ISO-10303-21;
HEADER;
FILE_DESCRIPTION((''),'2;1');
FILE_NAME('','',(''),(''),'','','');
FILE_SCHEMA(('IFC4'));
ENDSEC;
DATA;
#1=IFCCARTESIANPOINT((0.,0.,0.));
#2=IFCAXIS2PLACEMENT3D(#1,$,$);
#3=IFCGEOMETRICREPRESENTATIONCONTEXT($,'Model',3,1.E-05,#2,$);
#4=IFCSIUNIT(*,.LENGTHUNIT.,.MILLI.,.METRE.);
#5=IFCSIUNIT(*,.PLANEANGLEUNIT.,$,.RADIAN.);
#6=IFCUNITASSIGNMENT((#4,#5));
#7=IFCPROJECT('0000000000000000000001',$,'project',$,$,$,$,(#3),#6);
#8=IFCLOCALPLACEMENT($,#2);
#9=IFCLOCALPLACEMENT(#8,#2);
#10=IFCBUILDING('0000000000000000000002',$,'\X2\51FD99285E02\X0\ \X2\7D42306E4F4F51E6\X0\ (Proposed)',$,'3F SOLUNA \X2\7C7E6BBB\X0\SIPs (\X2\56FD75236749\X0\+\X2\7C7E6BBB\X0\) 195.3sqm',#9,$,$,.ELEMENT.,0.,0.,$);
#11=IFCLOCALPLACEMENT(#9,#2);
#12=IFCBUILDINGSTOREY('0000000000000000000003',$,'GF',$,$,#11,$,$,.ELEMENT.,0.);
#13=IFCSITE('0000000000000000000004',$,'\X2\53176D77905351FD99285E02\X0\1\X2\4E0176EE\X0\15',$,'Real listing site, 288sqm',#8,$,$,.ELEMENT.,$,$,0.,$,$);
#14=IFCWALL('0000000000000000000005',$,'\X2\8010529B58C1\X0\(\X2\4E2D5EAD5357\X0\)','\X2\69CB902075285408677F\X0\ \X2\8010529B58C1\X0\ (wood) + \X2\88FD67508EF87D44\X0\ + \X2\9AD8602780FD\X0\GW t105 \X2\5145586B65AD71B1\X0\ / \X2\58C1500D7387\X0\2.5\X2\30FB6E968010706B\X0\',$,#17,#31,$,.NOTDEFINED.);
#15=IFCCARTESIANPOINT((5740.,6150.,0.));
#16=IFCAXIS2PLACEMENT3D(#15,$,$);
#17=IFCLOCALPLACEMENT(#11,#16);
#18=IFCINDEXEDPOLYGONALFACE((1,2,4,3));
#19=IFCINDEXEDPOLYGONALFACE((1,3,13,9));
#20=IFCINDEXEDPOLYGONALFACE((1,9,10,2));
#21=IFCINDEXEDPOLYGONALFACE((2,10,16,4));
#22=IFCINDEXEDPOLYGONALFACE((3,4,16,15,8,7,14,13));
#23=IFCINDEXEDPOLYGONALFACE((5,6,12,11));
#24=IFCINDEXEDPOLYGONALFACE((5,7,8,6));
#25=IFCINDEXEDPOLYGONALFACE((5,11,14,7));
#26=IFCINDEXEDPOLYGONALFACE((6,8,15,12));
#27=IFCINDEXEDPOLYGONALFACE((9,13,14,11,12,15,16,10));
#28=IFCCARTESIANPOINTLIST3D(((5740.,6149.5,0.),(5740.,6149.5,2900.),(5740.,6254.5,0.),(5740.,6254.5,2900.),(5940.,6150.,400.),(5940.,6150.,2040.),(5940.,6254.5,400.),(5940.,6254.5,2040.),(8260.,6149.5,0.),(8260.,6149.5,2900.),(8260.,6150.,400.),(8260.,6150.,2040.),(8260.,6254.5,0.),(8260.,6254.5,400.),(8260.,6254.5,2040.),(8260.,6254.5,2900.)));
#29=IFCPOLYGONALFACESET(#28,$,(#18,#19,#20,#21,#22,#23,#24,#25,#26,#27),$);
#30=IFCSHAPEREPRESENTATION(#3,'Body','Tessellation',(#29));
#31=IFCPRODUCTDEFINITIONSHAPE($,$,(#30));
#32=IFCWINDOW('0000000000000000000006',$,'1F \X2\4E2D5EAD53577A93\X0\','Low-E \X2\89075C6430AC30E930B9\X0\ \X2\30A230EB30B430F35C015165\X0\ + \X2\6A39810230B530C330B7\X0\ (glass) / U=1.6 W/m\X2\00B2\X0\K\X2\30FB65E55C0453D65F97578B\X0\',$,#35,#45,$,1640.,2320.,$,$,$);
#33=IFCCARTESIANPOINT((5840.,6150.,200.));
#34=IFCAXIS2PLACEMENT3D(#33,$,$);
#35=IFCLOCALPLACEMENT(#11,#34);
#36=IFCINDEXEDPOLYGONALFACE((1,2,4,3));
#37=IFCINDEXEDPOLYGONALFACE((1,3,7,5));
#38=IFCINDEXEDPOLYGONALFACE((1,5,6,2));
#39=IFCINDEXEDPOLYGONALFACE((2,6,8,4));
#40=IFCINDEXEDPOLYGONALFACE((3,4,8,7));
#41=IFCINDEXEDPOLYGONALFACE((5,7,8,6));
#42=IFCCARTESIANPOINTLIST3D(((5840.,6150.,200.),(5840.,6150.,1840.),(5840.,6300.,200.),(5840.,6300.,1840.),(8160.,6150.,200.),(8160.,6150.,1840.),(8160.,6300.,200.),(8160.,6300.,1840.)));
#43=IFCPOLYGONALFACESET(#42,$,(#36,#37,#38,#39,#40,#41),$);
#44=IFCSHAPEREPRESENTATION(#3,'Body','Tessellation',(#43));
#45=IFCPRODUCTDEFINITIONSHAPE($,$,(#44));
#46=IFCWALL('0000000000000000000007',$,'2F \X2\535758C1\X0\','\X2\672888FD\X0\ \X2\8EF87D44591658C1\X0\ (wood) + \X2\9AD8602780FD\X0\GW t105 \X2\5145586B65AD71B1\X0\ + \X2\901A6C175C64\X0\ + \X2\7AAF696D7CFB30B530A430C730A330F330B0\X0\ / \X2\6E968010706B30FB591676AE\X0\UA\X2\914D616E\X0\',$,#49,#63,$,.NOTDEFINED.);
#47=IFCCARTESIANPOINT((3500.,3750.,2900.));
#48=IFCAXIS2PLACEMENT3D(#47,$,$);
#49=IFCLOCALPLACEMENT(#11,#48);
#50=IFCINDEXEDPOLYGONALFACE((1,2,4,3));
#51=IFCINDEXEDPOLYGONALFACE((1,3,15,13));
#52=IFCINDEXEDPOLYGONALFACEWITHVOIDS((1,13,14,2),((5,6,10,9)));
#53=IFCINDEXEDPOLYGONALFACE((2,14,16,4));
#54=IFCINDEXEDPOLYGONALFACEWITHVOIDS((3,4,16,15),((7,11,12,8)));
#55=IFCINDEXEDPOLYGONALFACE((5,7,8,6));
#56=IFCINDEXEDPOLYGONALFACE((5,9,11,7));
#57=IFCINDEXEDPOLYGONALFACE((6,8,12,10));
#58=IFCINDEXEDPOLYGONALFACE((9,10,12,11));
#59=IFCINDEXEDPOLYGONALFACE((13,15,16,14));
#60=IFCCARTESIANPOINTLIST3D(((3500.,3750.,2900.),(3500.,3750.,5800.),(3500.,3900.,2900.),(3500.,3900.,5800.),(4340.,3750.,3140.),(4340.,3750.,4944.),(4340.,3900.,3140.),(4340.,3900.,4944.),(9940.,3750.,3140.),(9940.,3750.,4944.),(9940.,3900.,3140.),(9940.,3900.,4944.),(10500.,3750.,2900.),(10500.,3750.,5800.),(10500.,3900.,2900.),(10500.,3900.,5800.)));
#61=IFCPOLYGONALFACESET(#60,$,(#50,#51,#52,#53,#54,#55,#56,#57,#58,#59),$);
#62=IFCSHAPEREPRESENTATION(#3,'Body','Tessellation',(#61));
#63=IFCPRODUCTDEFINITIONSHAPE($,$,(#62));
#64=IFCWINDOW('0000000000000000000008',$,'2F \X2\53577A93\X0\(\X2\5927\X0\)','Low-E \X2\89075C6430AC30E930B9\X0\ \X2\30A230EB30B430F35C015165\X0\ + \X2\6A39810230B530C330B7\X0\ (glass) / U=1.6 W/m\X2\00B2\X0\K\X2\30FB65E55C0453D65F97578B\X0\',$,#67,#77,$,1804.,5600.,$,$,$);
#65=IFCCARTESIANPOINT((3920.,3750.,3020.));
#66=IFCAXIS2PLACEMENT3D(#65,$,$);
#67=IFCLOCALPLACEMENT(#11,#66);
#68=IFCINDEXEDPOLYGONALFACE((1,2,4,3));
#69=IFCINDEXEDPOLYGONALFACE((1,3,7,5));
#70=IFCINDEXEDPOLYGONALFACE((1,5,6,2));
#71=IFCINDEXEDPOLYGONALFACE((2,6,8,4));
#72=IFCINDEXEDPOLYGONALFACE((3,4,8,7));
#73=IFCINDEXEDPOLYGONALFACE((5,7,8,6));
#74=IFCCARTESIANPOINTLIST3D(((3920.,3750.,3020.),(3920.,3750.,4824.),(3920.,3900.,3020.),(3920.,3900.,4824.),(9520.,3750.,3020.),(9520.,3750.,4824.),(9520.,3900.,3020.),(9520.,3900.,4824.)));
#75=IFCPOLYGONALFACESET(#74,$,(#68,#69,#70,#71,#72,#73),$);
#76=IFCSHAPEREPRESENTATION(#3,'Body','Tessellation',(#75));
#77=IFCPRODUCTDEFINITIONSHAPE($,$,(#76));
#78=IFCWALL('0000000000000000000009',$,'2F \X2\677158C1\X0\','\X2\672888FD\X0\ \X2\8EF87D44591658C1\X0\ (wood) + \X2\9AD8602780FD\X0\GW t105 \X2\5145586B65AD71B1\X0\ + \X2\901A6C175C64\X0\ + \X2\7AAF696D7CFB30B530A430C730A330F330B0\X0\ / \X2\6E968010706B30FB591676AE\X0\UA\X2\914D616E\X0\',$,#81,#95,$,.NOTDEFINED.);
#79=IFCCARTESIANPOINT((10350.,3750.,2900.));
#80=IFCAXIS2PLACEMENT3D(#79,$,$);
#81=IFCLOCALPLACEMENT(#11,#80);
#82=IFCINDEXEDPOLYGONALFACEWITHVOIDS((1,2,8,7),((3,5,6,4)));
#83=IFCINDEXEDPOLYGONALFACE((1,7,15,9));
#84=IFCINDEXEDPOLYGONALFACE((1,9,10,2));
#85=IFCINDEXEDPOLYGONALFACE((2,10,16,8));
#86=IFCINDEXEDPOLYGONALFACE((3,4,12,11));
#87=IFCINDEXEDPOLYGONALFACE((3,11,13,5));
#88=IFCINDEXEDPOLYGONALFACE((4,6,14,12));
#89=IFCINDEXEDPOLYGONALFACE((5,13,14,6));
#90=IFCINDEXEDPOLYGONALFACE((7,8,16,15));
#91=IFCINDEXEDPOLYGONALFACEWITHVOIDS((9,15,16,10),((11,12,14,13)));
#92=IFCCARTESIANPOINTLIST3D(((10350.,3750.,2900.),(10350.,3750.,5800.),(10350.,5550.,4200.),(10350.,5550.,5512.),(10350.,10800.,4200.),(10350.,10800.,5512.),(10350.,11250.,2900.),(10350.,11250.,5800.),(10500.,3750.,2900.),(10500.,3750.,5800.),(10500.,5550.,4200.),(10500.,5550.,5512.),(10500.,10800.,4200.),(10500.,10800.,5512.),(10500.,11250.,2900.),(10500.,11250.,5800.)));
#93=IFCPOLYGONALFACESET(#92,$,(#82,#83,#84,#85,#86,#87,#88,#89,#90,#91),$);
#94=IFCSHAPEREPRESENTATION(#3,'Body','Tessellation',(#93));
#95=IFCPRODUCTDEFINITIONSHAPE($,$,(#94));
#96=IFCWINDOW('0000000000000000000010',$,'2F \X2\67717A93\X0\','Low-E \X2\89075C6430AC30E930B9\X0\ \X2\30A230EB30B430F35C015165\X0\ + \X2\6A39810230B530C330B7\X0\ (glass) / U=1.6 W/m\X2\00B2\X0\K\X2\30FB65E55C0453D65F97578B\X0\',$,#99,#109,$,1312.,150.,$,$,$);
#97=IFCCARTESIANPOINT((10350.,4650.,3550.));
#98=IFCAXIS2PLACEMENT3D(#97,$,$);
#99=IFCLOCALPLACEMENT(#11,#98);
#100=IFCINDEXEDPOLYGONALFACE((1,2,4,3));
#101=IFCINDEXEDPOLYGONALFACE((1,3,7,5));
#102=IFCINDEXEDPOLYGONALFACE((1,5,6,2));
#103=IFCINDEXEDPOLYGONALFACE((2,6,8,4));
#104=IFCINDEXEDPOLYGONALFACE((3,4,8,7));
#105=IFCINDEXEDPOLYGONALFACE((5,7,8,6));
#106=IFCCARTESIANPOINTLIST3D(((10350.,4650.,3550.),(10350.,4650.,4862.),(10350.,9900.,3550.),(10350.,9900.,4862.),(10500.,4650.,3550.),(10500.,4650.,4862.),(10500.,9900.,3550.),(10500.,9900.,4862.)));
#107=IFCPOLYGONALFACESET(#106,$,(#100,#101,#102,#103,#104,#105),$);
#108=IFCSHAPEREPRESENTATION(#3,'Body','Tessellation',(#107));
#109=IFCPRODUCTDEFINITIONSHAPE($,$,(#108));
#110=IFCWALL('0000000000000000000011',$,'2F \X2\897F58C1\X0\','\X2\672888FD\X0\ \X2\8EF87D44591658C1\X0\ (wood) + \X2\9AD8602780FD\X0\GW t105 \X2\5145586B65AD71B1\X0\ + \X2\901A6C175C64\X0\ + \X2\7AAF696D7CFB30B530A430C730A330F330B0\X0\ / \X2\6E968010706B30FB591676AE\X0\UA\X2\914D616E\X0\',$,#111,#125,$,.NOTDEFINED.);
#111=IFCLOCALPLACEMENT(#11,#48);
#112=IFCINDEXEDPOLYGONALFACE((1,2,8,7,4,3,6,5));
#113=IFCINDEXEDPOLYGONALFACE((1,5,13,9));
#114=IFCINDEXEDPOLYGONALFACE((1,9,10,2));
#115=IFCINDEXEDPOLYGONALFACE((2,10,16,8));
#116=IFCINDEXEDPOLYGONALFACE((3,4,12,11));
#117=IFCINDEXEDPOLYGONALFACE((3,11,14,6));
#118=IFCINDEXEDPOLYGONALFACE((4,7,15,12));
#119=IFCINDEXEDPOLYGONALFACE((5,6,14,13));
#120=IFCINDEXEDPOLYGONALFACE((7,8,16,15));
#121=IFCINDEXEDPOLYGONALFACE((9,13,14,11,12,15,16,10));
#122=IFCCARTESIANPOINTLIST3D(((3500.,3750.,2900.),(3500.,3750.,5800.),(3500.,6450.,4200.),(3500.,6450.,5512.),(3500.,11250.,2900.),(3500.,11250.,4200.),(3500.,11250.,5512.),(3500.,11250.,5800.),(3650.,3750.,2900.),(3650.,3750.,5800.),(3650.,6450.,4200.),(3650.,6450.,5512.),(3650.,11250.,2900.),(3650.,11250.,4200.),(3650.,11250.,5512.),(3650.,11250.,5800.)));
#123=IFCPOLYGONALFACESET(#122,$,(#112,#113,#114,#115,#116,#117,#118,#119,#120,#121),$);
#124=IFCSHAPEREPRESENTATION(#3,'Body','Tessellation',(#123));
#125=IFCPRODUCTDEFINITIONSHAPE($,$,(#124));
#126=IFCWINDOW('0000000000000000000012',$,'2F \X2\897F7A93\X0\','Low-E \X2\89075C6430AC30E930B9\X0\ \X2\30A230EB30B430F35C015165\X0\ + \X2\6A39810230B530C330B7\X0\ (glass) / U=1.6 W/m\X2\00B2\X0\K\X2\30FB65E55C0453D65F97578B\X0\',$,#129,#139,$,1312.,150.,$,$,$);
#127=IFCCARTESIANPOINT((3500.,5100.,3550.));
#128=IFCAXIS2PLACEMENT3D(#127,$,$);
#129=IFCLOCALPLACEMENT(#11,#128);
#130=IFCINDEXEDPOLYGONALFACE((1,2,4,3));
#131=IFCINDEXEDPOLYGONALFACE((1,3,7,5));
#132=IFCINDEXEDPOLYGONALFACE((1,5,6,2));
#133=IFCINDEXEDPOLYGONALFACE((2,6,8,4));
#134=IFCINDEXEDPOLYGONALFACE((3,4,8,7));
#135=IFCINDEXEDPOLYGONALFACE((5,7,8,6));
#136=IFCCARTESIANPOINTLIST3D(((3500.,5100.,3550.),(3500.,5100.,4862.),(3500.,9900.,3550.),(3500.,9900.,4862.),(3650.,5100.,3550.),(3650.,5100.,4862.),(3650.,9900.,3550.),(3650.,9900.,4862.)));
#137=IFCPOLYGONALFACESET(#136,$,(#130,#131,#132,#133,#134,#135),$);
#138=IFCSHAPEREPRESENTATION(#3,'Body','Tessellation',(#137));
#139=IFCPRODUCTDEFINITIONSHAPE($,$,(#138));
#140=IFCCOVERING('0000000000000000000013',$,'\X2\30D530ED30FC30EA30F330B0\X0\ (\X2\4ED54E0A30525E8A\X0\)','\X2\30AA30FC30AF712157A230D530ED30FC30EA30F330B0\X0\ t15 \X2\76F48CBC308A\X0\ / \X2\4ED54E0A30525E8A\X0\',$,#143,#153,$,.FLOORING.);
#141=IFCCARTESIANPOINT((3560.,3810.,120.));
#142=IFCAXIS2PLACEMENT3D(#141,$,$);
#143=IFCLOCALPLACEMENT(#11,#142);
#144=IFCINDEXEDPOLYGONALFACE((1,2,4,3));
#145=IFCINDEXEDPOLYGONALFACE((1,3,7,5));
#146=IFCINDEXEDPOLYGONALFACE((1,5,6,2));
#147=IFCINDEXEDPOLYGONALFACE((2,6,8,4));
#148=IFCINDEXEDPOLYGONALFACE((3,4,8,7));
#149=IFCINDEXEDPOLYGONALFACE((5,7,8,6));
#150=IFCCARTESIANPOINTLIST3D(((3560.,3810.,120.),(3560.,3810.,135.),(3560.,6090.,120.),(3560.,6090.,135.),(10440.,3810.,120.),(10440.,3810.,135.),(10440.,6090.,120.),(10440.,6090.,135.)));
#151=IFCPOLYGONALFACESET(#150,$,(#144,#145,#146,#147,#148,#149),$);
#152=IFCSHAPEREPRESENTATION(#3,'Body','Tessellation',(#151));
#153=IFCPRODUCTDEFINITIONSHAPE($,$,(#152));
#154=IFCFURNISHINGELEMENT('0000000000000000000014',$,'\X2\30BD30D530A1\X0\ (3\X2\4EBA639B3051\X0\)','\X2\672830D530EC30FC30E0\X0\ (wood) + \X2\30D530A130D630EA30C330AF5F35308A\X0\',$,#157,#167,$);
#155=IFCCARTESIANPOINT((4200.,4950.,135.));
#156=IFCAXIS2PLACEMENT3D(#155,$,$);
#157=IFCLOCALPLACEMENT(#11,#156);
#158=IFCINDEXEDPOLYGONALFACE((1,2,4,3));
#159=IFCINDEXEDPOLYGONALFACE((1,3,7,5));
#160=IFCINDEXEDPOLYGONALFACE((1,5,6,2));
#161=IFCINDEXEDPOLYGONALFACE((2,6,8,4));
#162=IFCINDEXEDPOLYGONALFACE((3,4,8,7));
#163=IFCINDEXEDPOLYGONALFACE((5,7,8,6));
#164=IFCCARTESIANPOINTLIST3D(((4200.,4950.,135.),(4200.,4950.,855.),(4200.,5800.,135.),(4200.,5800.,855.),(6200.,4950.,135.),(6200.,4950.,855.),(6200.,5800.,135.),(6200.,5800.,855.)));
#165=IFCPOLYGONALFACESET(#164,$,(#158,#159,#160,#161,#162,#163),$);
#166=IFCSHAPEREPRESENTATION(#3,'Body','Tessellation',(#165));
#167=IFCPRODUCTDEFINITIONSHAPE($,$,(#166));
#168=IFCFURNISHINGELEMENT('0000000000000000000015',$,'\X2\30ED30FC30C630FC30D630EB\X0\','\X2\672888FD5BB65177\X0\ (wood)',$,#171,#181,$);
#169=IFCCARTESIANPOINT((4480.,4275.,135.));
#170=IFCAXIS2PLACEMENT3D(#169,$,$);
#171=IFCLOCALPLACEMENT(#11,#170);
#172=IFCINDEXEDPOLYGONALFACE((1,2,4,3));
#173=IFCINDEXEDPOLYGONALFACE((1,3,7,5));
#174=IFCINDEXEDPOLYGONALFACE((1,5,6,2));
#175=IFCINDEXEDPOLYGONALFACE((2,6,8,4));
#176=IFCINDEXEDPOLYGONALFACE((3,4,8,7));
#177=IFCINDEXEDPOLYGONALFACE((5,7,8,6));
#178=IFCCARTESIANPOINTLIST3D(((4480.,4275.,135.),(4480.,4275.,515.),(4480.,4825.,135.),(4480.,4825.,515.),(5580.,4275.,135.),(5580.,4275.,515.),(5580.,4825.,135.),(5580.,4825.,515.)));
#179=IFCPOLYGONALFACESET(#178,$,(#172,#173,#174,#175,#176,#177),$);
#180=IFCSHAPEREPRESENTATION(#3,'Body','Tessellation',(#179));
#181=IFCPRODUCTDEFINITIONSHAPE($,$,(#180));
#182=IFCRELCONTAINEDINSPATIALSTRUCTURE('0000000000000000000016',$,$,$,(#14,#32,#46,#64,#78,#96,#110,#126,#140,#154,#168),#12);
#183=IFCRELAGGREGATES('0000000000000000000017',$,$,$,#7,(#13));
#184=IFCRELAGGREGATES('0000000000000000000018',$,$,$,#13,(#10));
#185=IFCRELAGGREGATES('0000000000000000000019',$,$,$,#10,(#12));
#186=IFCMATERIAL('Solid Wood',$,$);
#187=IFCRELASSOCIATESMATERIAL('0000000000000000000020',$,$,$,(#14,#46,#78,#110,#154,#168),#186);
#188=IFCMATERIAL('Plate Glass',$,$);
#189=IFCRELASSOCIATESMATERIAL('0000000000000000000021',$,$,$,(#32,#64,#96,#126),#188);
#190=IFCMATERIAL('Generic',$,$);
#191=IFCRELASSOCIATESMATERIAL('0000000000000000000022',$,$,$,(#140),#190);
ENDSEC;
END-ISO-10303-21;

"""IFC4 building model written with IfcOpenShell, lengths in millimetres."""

from ifc_helpers import new_model, si_unit, frame, frame_2d, origin, place, context, project, spatial, rectangle, extrude, material, element, fill, save


model = new_model("IFC4")

# Units and contexts
model_context = context("Model", 3, precision=1e-05, world=origin())
ifc_project = project(units=[si_unit("LENGTHUNIT", "METRE", prefix="MILLI"), si_unit("PLANEANGLEUNIT", "RADIAN")], contexts=[model_context])

# Site, building, storey
site_placement = place(None, origin())
site = spatial("IfcSite", under=ifc_project, at=site_placement, Name="北海道函館市1丁目15", ObjectType="Real listing site, 288sqm", CompositionType="ELEMENT", RefElevation=0.0)
building_placement = place(site_placement, origin())
building = spatial("IfcBuilding", under=site, at=building_placement, Name="函館市 終の住処 (Proposed)", ObjectType="3F SOLUNA 籾殻SIPs (国産杉+籾殻) 195.3sqm", CompositionType="ELEMENT", ElevationOfRefHeight=0.0, ElevationOfTerrain=0.0)
storey_placement = place(building_placement, origin())
storey = spatial("IfcBuildingStorey", under=building, at=storey_placement, Name="GF", CompositionType="ELEMENT", Elevation=0.0)

# Shared definitions
ifc_material_1 = material(Name="Solid Wood")

# Shared definitions
ifc_material_2 = material(Name="Plate Glass")

# Walls, openings, windows
wall_1_placement = place(storey_placement, frame((5740.0, 6150.0, 0.0)))
wall_1 = element("IfcWall", 1, at=wall_1_placement, inside=storey, material=ifc_material_1, Name="耐力壁(中庭南)", Description="構造用合板 耐力壁 (wood) + 製材軸組 + 高性能GW t105 充填断熱 / 壁倍率2.5・準耐火", PredefinedType="NOTDEFINED", context=model_context, shape_type="SweptSolid", body=[
    extrude(rectangle(XDim=2520.0, YDim=105.0, at=frame_2d((1260.0, 52.0))), frame((5740.0, 6150.0, 0.0)), (0.0, 0.0, 1.0), 2900.0),
])
opening_1_placement = place(storey_placement, frame((5840.0, 6150.0, 200.0)))
opening_1 = element("IfcOpeningElement", 2, at=opening_1_placement, cuts=wall_1, PredefinedType="NOTDEFINED", context=model_context, shape_type="SweptSolid", body=[
    extrude(rectangle(XDim=2320.0, YDim=150.0, at=frame_2d((1160.0, 75.0))), frame((5840.0, 6150.0, 200.0)), (0.0, 0.0, 1.0), 1640.0),
])
window_1_placement = place(storey_placement, frame((5840.0, 6150.0, 200.0)))
window_1 = element("IfcWindow", 3, at=window_1_placement, inside=storey, material=ifc_material_2, Name="1F 中庭南窓", Description="Low-E 複層ガラス アルゴン封入 + 樹脂サッシ (glass) / U=1.6 W/m²K・日射取得型", OverallHeight=1640.0, OverallWidth=2320.0, context=model_context, shape_type="SweptSolid", body=[
    extrude(rectangle(XDim=2320.0, YDim=150.0, at=frame_2d((1160.0, 75.0))), frame((5840.0, 6150.0, 200.0)), (0.0, 0.0, 1.0), 1640.0),
])
fill(opening_1, window_1)
wall_2_placement = place(storey_placement, frame((3500.0, 3750.0, 2900.0)))
wall_2 = element("IfcWall", 4, at=wall_2_placement, inside=storey, material=ifc_material_1, Name="2F 南壁", Description="木製 軸組外壁 (wood) + 高性能GW t105 充填断熱 + 通気層 + 窯業系サイディング / 準耐火・外皮UA配慮", PredefinedType="NOTDEFINED", context=model_context, shape_type="SweptSolid", body=[
    extrude(rectangle(XDim=7000.0, YDim=150.0, at=frame_2d((3500.0, 75.0))), frame((3500.0, 3750.0, 2900.0)), (0.0, 0.0, 1.0), 2900.0),
])
opening_2_placement = place(storey_placement, frame((3920.0, 3750.0, 3020.0)))
opening_2 = element("IfcOpeningElement", 5, at=opening_2_placement, cuts=wall_2, PredefinedType="NOTDEFINED", context=model_context, shape_type="SweptSolid", body=[
    extrude(rectangle(XDim=5600.0, YDim=150.0, at=frame_2d((2800.0, 75.0))), frame((3920.0, 3750.0, 3020.0)), (0.0, 0.0, 1.0), 1804.0),
])
window_2_placement = place(storey_placement, frame((3920.0, 3750.0, 3020.0)))
window_2 = element("IfcWindow", 6, at=window_2_placement, inside=storey, material=ifc_material_2, Name="2F 南窓(大)", Description="Low-E 複層ガラス アルゴン封入 + 樹脂サッシ (glass) / U=1.6 W/m²K・日射取得型", OverallHeight=1804.0, OverallWidth=5600.0, context=model_context, shape_type="SweptSolid", body=[
    extrude(rectangle(XDim=5600.0, YDim=150.0, at=frame_2d((2800.0, 75.0))), frame((3920.0, 3750.0, 3020.0)), (0.0, 0.0, 1.0), 1804.0),
])
fill(opening_2, window_2)
wall_3_placement = place(storey_placement, frame((10350.0, 3750.0, 2900.0)))
wall_3 = element("IfcWall", 7, at=wall_3_placement, inside=storey, material=ifc_material_1, Name="2F 東壁", Description="木製 軸組外壁 (wood) + 高性能GW t105 充填断熱 + 通気層 + 窯業系サイディング / 準耐火・外皮UA配慮", PredefinedType="NOTDEFINED", context=model_context, shape_type="SweptSolid", body=[
    extrude(rectangle(XDim=150.0, YDim=7500.0, at=frame_2d((75.0, 3750.0))), frame((10350.0, 3750.0, 2900.0)), (0.0, 0.0, 1.0), 2900.0),
])
opening_3_placement = place(storey_placement, frame((10350.0, 4650.0, 3550.0)))
opening_3 = element("IfcOpeningElement", 8, at=opening_3_placement, cuts=wall_3, PredefinedType="NOTDEFINED", context=model_context, shape_type="SweptSolid", body=[
    extrude(rectangle(XDim=150.0, YDim=5250.0, at=frame_2d((75.0, 2625.0))), frame((10350.0, 4650.0, 3550.0)), (0.0, 0.0, 1.0), 1312.0),
])
window_3_placement = place(storey_placement, frame((10350.0, 4650.0, 3550.0)))
window_3 = element("IfcWindow", 9, at=window_3_placement, inside=storey, material=ifc_material_2, Name="2F 東窓", Description="Low-E 複層ガラス アルゴン封入 + 樹脂サッシ (glass) / U=1.6 W/m²K・日射取得型", OverallHeight=1312.0, OverallWidth=150.0, context=model_context, shape_type="SweptSolid", body=[
    extrude(rectangle(XDim=150.0, YDim=5250.0, at=frame_2d((75.0, 2625.0))), frame((10350.0, 4650.0, 3550.0)), (0.0, 0.0, 1.0), 1312.0),
])
fill(opening_3, window_3)
wall_4_placement = place(storey_placement, frame((3500.0, 3750.0, 2900.0)))
wall_4 = element("IfcWall", 10, at=wall_4_placement, inside=storey, material=ifc_material_1, Name="2F 西壁", Description="木製 軸組外壁 (wood) + 高性能GW t105 充填断熱 + 通気層 + 窯業系サイディング / 準耐火・外皮UA配慮", PredefinedType="NOTDEFINED", context=model_context, shape_type="SweptSolid", body=[
    extrude(rectangle(XDim=150.0, YDim=7500.0, at=frame_2d((75.0, 3750.0))), frame((3500.0, 3750.0, 2900.0)), (0.0, 0.0, 1.0), 2900.0),
])
opening_4_placement = place(storey_placement, frame((3500.0, 5100.0, 3550.0)))
opening_4 = element("IfcOpeningElement", 11, at=opening_4_placement, cuts=wall_4, PredefinedType="NOTDEFINED", context=model_context, shape_type="SweptSolid", body=[
    extrude(rectangle(XDim=150.0, YDim=4800.0, at=frame_2d((75.0, 2400.0))), frame((3500.0, 5100.0, 3550.0)), (0.0, 0.0, 1.0), 1312.0),
])
window_4_placement = place(storey_placement, frame((3500.0, 5100.0, 3550.0)))
window_4 = element("IfcWindow", 12, at=window_4_placement, inside=storey, material=ifc_material_2, Name="2F 西窓", Description="Low-E 複層ガラス アルゴン封入 + 樹脂サッシ (glass) / U=1.6 W/m²K・日射取得型", OverallHeight=1312.0, OverallWidth=150.0, context=model_context, shape_type="SweptSolid", body=[
    extrude(rectangle(XDim=150.0, YDim=4800.0, at=frame_2d((75.0, 2400.0))), frame((3500.0, 5100.0, 3550.0)), (0.0, 0.0, 1.0), 1312.0),
])
fill(opening_4, window_4)

# Covering
ifc_material_3 = material(Name="Generic")
covering_placement = place(storey_placement, frame((3560.0, 3810.0, 120.0)))
element("IfcCovering", 13, at=covering_placement, inside=storey, material=ifc_material_3, Name="フローリング (仕上げ床)", Description="オーク無垢フローリング t15 直貼り / 仕上げ床", PredefinedType="FLOORING", context=model_context, shape_type="SweptSolid", body=[
    extrude(rectangle(XDim=6880.0, YDim=2280.0, at=frame_2d((3440.0, 1140.0))), frame((3560.0, 3810.0, 120.0)), (0.0, 0.0, 1.0), 15.0),
])

# Furnishing elements
furnishing_1_placement = place(storey_placement, frame((4200.0, 4950.0, 135.0)))
element("IfcFurnishingElement", 14, at=furnishing_1_placement, inside=storey, material=ifc_material_1, Name="ソファ (3人掛け)", Description="木フレーム (wood) + ファブリック張り", context=model_context, shape_type="SweptSolid", body=[
    extrude(rectangle(XDim=2000.0, YDim=850.0, at=frame_2d((1000.0, 425.0))), frame((4200.0, 4950.0, 135.0)), (0.0, 0.0, 1.0), 720.0),
])
furnishing_2_placement = place(storey_placement, frame((4480.0, 4275.0, 135.0)))
element("IfcFurnishingElement", 15, at=furnishing_2_placement, inside=storey, material=ifc_material_1, Name="ローテーブル", Description="木製家具 (wood)", context=model_context, shape_type="SweptSolid", body=[
    extrude(rectangle(XDim=1100.0, YDim=550.0, at=frame_2d((550.0, 275.0))), frame((4480.0, 4275.0, 135.0)), (0.0, 0.0, 1.0), 380.0),
])

save(model, "model.ifc")
